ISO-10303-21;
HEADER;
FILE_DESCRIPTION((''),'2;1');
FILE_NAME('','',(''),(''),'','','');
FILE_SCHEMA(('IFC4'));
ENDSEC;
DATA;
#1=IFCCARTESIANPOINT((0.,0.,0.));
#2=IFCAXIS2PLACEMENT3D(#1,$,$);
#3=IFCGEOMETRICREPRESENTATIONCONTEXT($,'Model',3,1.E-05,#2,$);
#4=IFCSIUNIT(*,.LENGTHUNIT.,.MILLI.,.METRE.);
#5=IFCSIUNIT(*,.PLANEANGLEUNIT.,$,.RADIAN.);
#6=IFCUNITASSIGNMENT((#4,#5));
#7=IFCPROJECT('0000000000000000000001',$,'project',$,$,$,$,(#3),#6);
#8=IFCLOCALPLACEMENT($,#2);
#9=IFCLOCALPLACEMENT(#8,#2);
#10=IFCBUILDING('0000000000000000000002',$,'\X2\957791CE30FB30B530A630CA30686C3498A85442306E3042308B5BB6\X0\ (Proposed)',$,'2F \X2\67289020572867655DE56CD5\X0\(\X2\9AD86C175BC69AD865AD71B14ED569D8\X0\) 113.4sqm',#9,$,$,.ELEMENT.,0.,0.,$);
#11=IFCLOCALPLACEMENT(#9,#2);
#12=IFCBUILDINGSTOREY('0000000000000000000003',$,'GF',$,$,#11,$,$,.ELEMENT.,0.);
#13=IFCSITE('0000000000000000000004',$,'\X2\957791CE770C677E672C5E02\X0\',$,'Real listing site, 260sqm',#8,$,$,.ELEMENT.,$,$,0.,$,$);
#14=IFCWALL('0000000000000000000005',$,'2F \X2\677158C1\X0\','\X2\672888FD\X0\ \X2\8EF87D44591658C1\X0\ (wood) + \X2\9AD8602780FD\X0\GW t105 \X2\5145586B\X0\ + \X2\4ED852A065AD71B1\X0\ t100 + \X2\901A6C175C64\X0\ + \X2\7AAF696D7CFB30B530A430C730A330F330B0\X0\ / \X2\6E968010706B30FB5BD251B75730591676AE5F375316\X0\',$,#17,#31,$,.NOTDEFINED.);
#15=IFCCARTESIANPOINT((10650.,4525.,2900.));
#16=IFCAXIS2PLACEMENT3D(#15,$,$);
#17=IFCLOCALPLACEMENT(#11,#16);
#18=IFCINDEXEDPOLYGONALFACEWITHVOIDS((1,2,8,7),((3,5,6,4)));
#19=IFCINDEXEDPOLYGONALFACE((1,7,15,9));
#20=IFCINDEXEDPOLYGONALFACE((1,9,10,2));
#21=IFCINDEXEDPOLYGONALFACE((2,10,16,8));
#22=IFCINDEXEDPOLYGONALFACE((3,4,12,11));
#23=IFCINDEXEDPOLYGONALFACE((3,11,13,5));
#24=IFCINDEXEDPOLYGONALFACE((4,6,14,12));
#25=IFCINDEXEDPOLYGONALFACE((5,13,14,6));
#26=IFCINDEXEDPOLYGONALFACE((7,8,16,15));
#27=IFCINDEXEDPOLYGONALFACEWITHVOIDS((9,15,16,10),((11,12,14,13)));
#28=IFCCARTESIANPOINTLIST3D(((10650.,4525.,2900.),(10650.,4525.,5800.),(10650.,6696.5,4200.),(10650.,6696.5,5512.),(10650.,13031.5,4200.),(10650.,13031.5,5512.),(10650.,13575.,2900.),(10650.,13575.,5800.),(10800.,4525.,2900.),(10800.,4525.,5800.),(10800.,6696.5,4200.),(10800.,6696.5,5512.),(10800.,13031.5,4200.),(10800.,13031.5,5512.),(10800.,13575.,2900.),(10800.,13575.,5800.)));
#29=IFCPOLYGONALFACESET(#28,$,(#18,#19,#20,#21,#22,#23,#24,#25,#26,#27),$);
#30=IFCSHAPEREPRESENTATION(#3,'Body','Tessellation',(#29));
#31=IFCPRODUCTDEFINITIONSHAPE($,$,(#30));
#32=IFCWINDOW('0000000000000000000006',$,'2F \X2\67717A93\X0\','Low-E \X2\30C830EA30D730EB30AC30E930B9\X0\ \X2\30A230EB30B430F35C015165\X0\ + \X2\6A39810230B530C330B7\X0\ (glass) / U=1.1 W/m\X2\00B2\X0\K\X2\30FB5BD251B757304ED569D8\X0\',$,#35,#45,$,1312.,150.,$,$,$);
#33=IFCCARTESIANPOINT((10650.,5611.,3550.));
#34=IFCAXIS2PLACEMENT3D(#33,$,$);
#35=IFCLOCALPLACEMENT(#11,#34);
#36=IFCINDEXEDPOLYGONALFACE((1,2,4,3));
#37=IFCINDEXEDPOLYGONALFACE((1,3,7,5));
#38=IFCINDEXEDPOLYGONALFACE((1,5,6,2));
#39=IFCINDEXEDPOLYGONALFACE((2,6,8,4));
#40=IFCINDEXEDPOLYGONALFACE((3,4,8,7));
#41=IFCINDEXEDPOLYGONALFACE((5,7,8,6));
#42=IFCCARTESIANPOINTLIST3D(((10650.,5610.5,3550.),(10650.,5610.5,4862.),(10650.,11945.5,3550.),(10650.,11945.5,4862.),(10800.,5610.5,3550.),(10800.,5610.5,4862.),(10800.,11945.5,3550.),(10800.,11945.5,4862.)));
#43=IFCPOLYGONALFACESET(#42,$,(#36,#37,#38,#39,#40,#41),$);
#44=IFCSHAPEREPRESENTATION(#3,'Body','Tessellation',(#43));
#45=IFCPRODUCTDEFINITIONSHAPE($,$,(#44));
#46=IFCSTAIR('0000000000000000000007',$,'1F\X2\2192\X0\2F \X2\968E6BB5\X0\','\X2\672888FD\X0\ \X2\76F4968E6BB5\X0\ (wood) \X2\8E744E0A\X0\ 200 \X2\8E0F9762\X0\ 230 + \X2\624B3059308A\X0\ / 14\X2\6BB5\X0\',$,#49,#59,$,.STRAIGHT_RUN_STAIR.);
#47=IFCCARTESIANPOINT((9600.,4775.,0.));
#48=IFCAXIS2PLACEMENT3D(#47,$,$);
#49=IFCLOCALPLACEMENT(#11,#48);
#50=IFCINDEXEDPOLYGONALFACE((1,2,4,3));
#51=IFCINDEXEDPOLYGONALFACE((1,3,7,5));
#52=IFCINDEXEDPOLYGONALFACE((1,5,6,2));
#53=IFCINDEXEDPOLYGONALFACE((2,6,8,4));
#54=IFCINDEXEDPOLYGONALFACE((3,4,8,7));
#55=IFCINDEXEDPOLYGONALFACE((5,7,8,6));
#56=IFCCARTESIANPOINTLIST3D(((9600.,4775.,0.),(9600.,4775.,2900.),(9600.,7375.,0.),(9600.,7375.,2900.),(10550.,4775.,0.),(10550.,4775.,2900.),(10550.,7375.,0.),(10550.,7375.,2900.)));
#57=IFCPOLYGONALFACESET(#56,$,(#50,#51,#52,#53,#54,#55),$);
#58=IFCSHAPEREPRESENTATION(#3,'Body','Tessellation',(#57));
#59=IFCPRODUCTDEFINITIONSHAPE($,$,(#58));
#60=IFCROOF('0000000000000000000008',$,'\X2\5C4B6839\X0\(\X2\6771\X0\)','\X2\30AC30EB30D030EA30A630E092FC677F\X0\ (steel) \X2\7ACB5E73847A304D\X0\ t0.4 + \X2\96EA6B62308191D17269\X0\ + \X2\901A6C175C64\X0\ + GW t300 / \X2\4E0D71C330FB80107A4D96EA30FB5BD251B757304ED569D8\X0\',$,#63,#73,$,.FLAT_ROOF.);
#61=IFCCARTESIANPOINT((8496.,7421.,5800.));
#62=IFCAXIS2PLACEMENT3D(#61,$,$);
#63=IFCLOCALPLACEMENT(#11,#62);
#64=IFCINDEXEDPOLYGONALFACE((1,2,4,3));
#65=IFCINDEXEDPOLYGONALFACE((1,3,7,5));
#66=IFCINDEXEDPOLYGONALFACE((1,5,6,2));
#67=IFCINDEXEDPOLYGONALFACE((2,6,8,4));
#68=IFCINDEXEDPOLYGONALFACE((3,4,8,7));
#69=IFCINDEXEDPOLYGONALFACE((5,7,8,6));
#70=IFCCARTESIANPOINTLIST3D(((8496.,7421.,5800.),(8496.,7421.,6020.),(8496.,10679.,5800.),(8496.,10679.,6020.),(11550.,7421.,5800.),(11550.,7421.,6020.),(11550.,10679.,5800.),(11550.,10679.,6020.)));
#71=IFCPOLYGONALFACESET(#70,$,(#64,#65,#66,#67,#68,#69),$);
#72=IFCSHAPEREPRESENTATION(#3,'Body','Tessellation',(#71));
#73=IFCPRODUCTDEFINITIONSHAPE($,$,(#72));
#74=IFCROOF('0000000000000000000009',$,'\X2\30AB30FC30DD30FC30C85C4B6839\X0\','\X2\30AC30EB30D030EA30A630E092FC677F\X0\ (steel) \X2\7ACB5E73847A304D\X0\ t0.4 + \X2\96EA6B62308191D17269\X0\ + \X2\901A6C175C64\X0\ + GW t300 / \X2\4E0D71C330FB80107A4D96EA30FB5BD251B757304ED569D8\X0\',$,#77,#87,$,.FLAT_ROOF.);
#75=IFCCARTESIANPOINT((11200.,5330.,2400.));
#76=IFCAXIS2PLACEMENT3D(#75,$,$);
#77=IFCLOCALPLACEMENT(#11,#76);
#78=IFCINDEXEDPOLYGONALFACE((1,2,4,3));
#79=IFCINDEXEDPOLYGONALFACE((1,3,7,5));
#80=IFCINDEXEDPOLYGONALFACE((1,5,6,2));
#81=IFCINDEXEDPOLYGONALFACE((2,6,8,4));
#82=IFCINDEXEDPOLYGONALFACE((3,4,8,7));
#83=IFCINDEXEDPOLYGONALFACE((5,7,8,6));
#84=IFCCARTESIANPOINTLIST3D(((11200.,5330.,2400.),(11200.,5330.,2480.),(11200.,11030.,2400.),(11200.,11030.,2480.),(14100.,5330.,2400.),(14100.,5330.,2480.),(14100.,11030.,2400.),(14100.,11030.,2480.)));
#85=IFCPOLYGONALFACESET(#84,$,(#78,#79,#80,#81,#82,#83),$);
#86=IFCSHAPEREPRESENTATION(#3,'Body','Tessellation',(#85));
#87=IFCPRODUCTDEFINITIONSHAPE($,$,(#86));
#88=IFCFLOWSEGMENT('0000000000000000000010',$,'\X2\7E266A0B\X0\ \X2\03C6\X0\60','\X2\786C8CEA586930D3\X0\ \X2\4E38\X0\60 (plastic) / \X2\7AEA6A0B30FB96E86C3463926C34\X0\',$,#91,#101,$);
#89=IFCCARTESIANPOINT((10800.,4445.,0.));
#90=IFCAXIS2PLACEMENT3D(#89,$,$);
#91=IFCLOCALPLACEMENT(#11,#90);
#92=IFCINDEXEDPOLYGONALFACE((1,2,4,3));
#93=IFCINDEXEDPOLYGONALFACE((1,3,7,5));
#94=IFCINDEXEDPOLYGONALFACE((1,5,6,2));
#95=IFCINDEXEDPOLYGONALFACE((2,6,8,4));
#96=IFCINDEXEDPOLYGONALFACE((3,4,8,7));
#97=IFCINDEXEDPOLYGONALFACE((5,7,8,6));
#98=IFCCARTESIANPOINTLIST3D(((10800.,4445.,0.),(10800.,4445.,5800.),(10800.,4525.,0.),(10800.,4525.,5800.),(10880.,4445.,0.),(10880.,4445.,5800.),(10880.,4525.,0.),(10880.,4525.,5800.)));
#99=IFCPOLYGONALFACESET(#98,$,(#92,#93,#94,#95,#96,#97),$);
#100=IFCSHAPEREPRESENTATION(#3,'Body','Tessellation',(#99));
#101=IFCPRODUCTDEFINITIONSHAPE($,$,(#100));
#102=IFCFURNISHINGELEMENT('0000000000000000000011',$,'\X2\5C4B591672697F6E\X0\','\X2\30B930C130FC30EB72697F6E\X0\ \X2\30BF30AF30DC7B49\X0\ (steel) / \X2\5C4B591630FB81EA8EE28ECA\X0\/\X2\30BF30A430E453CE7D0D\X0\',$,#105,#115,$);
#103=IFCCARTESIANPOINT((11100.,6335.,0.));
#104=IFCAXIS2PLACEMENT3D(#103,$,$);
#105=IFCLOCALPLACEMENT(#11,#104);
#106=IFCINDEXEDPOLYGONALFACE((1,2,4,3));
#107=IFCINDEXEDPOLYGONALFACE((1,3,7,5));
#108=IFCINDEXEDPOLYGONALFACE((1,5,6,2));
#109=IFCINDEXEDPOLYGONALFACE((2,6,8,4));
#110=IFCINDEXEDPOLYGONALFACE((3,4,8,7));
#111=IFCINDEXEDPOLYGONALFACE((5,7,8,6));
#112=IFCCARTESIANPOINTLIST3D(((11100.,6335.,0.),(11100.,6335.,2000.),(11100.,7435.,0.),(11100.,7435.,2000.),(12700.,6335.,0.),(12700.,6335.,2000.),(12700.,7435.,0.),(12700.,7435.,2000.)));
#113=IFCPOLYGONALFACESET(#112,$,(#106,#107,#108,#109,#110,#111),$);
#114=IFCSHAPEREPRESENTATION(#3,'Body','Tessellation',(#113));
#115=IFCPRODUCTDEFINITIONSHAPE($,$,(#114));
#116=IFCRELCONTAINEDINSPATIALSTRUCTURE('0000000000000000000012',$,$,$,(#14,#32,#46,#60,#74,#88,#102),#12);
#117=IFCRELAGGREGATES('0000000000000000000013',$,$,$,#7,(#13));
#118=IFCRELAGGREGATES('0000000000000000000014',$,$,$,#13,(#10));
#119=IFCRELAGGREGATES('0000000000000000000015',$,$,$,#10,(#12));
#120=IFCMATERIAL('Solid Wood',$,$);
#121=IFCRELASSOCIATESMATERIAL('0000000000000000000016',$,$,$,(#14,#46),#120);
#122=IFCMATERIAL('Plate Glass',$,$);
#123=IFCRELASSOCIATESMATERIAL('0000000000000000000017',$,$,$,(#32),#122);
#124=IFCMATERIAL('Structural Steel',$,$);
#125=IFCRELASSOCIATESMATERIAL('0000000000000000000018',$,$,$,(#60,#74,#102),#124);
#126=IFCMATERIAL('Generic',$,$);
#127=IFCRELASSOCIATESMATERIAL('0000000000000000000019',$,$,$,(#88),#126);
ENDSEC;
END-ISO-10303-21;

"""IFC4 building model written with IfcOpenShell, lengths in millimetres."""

from ifc_helpers import new_model, si_unit, frame, frame_2d, origin, place, context, project, spatial, rectangle, extrude, material, element, fill, save


model = new_model("IFC4")

# Units and contexts
model_context = context("Model", 3, precision=1e-05, world=origin())
ifc_project = project(units=[si_unit("LENGTHUNIT", "METRE", prefix="MILLI"), si_unit("PLANEANGLEUNIT", "RADIAN")], contexts=[model_context])

# Site, building, storey
site_placement = place(None, origin())
site = spatial("IfcSite", under=ifc_project, at=site_placement, Name="長野県松本市", ObjectType="Real listing site, 260sqm", CompositionType="ELEMENT", RefElevation=0.0)
building_placement = place(site_placement, origin())
building = spatial("IfcBuilding", under=site, at=building_placement, Name="長野・サウナと水風呂のある家 (Proposed)", ObjectType="2F 木造在来工法(高気密高断熱仕様) 113.4sqm", CompositionType="ELEMENT", ElevationOfRefHeight=0.0, ElevationOfTerrain=0.0)
storey_placement = place(building_placement, origin())
storey = spatial("IfcBuildingStorey", under=building, at=storey_placement, Name="GF", CompositionType="ELEMENT", Elevation=0.0)

# Shared definitions
ifc_material_1 = material(Name="Solid Wood")
ifc_material_2 = material(Name="Structural Steel")

# Wall, opening, window
ifc_material_3 = material(Name="Plate Glass")
wall_1_placement = place(storey_placement, frame((10650.0, 4525.0, 2900.0)))
wall_1 = element("IfcWall", 1, at=wall_1_placement, inside=storey, material=ifc_material_1, Name="2F 東壁", Description="木製 軸組外壁 (wood) + 高性能GW t105 充填 + 付加断熱 t100 + 通気層 + 窯業系サイディング / 準耐火・寒冷地外皮強化", PredefinedType="NOTDEFINED", context=model_context, shape_type="SweptSolid", body=[
    extrude(rectangle(XDim=150.0, YDim=9050.0, at=frame_2d((75.0, 4525.0))), frame((10650.0, 4525.0, 2900.0)), (0.0, 0.0, 1.0), 2900.0),
])
opening_1_placement = place(storey_placement, frame((10650.0, 5611.0, 3550.0)))
opening_1 = element("IfcOpeningElement", 2, at=opening_1_placement, cuts=wall_1, PredefinedType="NOTDEFINED", context=model_context, shape_type="SweptSolid", body=[
    extrude(rectangle(XDim=150.0, YDim=6335.0, at=frame_2d((75.0, 3167.0))), frame((10650.0, 5611.0, 3550.0)), (0.0, 0.0, 1.0), 1312.0),
])
window_1_placement = place(storey_placement, frame((10650.0, 5611.0, 3550.0)))
window_1 = element("IfcWindow", 3, at=window_1_placement, inside=storey, material=ifc_material_3, Name="2F 東窓", Description="Low-E トリプルガラス アルゴン封入 + 樹脂サッシ (glass) / U=1.1 W/m²K・寒冷地仕様", OverallHeight=1312.0, OverallWidth=150.0, context=model_context, shape_type="SweptSolid", body=[
    extrude(rectangle(XDim=150.0, YDim=6335.0, at=frame_2d((75.0, 3167.0))), frame((10650.0, 5611.0, 3550.0)), (0.0, 0.0, 1.0), 1312.0),
])
fill(opening_1, window_1)

# Stair
stair_placement = place(storey_placement, frame((9600.0, 4775.0, 0.0)))
element("IfcStair", 4, at=stair_placement, inside=storey, material=ifc_material_1, Name="1F→2F 階段", Description="木製 直階段 (wood) 蹴上 200 踏面 230 + 手すり / 14段", PredefinedType="STRAIGHT_RUN_STAIR", context=model_context, shape_type="SweptSolid", body=[
    extrude(rectangle(XDim=950.0, YDim=2600.0, at=frame_2d((475.0, 1300.0))), frame((9600.0, 4775.0, 0.0)), (0.0, 0.0, 1.0), 2900.0),
])

# Roofs
roof_1_placement = place(storey_placement, frame((8496.0, 7421.0, 5800.0)))
element("IfcRoof", 5, at=roof_1_placement, inside=storey, material=ifc_material_2, Name="屋根(東)", Description="ガルバリウム鋼板 (steel) 立平葺き t0.4 + 雪止め金物 + 通気層 + GW t300 / 不燃・耐積雪・寒冷地仕様", PredefinedType="FLAT_ROOF", context=model_context, shape_type="SweptSolid", body=[
    extrude(rectangle(XDim=3054.0, YDim=3258.0, at=frame_2d((1527.0, 1629.0))), frame((8496.0, 7421.0, 5800.0)), (0.0, 0.0, 1.0), 220.0),
])
roof_2_placement = place(storey_placement, frame((11200.0, 5330.0, 2400.0)))
element("IfcRoof", 6, at=roof_2_placement, inside=storey, material=ifc_material_2, Name="カーポート屋根", Description="ガルバリウム鋼板 (steel) 立平葺き t0.4 + 雪止め金物 + 通気層 + GW t300 / 不燃・耐積雪・寒冷地仕様", PredefinedType="FLAT_ROOF", context=model_context, shape_type="SweptSolid", body=[
    extrude(rectangle(XDim=2900.0, YDim=5700.0, at=frame_2d((1450.0, 2850.0))), frame((11200.0, 5330.0, 2400.0)), (0.0, 0.0, 1.0), 80.0),
])

# Flow segment
ifc_material_4 = material(Name="Generic")
flow_segment_placement = place(storey_placement, frame((10800.0, 4445.0, 0.0)))
element("IfcFlowSegment", 7, at=flow_segment_placement, inside=storey, material=ifc_material_4, Name="縦樋 φ60", Description="硬質塩ビ 丸60 (plastic) / 竪樋・雨水排水", context=model_context, shape_type="SweptSolid", body=[
    extrude(rectangle(XDim=80.0, YDim=80.0, at=frame_2d((40.0, 40.0))), frame((10800.0, 4445.0, 0.0)), (0.0, 0.0, 1.0), 5800.0),
])

# Furnishing element
furnishing_placement = place(storey_placement, frame((11100.0, 6335.0, 0.0)))
element("IfcFurnishingElement", 8, at=furnishing_placement, inside=storey, material=ifc_material_2, Name="屋外物置", Description="スチール物置 タクボ等 (steel) / 屋外・自転車/タイヤ収納", context=model_context, shape_type="SweptSolid", body=[
    extrude(rectangle(XDim=1600.0, YDim=1100.0, at=frame_2d((800.0, 550.0))), frame((11100.0, 6335.0, 0.0)), (0.0, 0.0, 1.0), 2000.0),
])

save(model, "model.ifc")
